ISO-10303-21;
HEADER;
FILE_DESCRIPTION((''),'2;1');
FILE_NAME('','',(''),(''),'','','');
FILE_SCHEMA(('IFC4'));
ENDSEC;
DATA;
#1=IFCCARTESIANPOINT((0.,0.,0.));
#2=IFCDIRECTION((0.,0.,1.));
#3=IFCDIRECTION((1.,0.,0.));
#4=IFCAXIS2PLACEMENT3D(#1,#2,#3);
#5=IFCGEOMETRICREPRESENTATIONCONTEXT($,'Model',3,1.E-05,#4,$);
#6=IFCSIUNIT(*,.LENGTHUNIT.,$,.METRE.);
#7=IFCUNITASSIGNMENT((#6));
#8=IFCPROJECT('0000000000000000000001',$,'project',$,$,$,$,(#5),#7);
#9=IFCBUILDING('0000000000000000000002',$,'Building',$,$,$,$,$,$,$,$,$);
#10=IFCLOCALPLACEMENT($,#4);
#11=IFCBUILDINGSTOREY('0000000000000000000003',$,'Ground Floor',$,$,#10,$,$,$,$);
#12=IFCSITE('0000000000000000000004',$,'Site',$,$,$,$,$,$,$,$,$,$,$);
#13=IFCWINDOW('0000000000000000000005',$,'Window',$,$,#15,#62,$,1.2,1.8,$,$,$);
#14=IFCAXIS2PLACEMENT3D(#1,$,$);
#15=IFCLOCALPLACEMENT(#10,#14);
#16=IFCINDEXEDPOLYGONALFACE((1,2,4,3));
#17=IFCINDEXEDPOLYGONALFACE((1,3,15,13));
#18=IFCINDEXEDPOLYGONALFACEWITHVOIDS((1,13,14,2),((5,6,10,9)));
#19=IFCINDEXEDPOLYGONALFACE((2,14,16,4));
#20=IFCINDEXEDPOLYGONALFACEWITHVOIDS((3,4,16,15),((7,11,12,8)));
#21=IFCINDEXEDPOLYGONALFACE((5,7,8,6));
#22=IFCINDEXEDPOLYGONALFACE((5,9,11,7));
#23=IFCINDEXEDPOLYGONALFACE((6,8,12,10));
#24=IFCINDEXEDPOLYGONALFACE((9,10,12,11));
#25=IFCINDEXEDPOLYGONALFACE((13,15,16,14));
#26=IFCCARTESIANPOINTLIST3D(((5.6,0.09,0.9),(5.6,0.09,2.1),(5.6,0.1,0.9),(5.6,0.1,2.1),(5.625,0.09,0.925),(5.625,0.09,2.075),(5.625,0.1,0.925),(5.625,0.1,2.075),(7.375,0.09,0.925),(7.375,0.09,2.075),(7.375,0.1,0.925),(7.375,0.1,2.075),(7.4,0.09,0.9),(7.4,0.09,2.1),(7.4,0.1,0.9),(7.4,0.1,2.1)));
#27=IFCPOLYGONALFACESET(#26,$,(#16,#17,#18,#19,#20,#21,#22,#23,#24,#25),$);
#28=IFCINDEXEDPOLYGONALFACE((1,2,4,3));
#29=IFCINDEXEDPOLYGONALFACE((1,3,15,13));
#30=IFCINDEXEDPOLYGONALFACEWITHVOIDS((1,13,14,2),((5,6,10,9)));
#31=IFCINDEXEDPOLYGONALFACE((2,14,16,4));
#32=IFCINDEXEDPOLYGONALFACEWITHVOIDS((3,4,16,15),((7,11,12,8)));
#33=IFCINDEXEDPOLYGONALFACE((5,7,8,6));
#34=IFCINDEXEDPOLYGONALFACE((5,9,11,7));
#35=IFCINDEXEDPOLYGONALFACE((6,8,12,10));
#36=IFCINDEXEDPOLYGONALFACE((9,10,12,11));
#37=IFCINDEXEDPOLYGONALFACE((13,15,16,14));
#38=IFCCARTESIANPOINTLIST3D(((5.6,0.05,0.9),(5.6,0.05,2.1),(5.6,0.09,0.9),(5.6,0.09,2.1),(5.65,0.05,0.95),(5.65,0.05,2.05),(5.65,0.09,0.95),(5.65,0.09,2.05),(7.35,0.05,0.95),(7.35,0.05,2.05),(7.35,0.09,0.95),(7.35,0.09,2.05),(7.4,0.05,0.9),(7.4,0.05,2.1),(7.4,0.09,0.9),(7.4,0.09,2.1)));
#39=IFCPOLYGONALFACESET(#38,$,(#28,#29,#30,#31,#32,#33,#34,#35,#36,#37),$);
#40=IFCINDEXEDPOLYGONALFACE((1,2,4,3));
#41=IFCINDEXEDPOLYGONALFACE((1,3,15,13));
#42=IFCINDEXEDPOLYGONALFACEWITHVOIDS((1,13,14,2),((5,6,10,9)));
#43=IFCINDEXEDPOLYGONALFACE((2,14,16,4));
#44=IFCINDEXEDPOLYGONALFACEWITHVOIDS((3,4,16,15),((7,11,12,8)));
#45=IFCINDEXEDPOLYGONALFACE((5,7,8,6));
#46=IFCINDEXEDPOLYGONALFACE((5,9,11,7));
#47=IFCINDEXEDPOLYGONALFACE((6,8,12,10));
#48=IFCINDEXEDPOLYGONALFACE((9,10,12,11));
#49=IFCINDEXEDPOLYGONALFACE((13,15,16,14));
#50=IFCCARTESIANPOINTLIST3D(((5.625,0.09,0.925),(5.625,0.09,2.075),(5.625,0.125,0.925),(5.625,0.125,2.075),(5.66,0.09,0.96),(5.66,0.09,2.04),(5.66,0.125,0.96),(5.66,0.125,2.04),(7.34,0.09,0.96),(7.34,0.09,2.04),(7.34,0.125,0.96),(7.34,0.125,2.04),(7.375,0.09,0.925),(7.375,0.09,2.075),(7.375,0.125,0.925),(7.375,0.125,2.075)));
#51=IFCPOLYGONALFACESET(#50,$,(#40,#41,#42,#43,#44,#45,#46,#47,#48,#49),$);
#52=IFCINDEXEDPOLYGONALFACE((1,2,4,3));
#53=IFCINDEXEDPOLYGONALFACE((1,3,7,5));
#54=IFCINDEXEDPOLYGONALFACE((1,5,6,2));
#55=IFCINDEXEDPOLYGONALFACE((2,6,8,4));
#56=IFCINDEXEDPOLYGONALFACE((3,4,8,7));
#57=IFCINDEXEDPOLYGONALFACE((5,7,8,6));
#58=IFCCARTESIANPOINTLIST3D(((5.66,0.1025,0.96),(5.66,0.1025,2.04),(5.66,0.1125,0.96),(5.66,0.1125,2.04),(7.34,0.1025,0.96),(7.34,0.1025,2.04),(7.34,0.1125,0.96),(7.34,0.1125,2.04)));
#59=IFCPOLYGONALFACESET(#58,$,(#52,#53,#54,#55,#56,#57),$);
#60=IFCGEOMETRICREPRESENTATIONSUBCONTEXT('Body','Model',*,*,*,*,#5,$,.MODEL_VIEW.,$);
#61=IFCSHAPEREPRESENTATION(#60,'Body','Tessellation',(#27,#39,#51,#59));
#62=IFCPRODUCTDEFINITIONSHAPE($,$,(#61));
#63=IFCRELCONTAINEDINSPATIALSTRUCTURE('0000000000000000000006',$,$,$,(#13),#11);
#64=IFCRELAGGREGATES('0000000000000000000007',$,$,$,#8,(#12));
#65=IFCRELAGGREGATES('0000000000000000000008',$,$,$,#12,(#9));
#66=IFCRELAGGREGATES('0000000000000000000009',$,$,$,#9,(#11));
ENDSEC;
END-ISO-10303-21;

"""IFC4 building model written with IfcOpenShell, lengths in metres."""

from ifc_helpers import new_model, si_unit, frame, origin_with_axes, place, context, subcontext, project, spatial, line, indexed_curve, outline, extrude, element, save


model = new_model("IFC4")

# Units and contexts
model_context = context("Model", 3, precision=1e-05, world=origin_with_axes())
body_context = subcontext(model_context, "Body", "Model", "MODEL_VIEW")
ifc_project = project(units=[si_unit("LENGTHUNIT", "METRE")], contexts=[model_context])

# Site, building, storey
site = spatial("IfcSite", under=ifc_project, Name="Site")
building = spatial("IfcBuilding", under=site, Name="Building")
storey_placement = place(None, origin_with_axes())
storey = spatial("IfcBuildingStorey", under=building, at=storey_placement, Name="Ground Floor")

# Window
for number, where, z_axis, x_axis, name in (
    (1, (5.6, 0.0, 0.9), (0.0, 0.0, 1.0), (1.0, 0.0, 0.0), "Window"),
):
    element("IfcWindow", number, at=place(storey_placement, frame(where, z_axis=z_axis, x_axis=x_axis)), inside=storey, Name=name, OverallHeight=1.2, OverallWidth=1.8, context=body_context, shape_type="SweptSolid", body=[
        extrude(outline(indexed_curve([(0.0, 0.0), (1.8, 0.0), (1.8, 1.2), (0.0, 1.2)], segments=[line(1, 2, 3, 4, 1)]), holes=[indexed_curve([(0.025, 0.025), (1.775, 0.025), (1.775, 1.175), (0.025, 1.175)], segments=[line(1, 2, 3, 4, 1)])]), frame((0.0, 0.09, 0.0), z_axis=(0.0, -1.0, 0.0), x_axis=(1.0, 0.0, 0.0)), (0.0, 0.0, -1.0), 0.01),
        extrude(outline(indexed_curve([(0.0, 0.0), (1.8, 0.0), (1.8, 1.2), (0.0, 1.2)], segments=[line(1, 2, 3, 4, 1)]), holes=[indexed_curve([(0.05, 0.05), (1.75, 0.05), (1.75, 1.15), (0.05, 1.15)], segments=[line(1, 2, 3, 4, 1)])]), frame((0.0, 0.05, 0.0), z_axis=(0.0, -1.0, 0.0), x_axis=(1.0, 0.0, 0.0)), (0.0, 0.0, -1.0), 0.04),
        extrude(outline(indexed_curve([(0.0, 0.0), (1.75, 0.0), (1.75, 1.15), (0.0, 1.15)], segments=[line(1, 2, 3, 4, 1)]), holes=[indexed_curve([(0.035, 0.035), (1.715, 0.035), (1.715, 1.115), (0.035, 1.115)], segments=[line(1, 2, 3, 4, 1)])]), frame((0.025, 0.09, 0.025), z_axis=(0.0, -1.0, 0.0), x_axis=(1.0, 0.0, 0.0)), (0.0, 0.0, -1.0), 0.035),
        extrude(outline(indexed_curve([(0.035, 0.035), (1.715, 0.035), (1.715, 1.115), (0.035, 1.115)], segments=[line(1, 2, 3, 4, 1)])), frame((0.025, 0.1025, 0.025), z_axis=(0.0, -1.0, 0.0), x_axis=(1.0, 0.0, 0.0)), (0.0, 0.0, -1.0), 0.01),
    ])

save(model, "model.ifc")
